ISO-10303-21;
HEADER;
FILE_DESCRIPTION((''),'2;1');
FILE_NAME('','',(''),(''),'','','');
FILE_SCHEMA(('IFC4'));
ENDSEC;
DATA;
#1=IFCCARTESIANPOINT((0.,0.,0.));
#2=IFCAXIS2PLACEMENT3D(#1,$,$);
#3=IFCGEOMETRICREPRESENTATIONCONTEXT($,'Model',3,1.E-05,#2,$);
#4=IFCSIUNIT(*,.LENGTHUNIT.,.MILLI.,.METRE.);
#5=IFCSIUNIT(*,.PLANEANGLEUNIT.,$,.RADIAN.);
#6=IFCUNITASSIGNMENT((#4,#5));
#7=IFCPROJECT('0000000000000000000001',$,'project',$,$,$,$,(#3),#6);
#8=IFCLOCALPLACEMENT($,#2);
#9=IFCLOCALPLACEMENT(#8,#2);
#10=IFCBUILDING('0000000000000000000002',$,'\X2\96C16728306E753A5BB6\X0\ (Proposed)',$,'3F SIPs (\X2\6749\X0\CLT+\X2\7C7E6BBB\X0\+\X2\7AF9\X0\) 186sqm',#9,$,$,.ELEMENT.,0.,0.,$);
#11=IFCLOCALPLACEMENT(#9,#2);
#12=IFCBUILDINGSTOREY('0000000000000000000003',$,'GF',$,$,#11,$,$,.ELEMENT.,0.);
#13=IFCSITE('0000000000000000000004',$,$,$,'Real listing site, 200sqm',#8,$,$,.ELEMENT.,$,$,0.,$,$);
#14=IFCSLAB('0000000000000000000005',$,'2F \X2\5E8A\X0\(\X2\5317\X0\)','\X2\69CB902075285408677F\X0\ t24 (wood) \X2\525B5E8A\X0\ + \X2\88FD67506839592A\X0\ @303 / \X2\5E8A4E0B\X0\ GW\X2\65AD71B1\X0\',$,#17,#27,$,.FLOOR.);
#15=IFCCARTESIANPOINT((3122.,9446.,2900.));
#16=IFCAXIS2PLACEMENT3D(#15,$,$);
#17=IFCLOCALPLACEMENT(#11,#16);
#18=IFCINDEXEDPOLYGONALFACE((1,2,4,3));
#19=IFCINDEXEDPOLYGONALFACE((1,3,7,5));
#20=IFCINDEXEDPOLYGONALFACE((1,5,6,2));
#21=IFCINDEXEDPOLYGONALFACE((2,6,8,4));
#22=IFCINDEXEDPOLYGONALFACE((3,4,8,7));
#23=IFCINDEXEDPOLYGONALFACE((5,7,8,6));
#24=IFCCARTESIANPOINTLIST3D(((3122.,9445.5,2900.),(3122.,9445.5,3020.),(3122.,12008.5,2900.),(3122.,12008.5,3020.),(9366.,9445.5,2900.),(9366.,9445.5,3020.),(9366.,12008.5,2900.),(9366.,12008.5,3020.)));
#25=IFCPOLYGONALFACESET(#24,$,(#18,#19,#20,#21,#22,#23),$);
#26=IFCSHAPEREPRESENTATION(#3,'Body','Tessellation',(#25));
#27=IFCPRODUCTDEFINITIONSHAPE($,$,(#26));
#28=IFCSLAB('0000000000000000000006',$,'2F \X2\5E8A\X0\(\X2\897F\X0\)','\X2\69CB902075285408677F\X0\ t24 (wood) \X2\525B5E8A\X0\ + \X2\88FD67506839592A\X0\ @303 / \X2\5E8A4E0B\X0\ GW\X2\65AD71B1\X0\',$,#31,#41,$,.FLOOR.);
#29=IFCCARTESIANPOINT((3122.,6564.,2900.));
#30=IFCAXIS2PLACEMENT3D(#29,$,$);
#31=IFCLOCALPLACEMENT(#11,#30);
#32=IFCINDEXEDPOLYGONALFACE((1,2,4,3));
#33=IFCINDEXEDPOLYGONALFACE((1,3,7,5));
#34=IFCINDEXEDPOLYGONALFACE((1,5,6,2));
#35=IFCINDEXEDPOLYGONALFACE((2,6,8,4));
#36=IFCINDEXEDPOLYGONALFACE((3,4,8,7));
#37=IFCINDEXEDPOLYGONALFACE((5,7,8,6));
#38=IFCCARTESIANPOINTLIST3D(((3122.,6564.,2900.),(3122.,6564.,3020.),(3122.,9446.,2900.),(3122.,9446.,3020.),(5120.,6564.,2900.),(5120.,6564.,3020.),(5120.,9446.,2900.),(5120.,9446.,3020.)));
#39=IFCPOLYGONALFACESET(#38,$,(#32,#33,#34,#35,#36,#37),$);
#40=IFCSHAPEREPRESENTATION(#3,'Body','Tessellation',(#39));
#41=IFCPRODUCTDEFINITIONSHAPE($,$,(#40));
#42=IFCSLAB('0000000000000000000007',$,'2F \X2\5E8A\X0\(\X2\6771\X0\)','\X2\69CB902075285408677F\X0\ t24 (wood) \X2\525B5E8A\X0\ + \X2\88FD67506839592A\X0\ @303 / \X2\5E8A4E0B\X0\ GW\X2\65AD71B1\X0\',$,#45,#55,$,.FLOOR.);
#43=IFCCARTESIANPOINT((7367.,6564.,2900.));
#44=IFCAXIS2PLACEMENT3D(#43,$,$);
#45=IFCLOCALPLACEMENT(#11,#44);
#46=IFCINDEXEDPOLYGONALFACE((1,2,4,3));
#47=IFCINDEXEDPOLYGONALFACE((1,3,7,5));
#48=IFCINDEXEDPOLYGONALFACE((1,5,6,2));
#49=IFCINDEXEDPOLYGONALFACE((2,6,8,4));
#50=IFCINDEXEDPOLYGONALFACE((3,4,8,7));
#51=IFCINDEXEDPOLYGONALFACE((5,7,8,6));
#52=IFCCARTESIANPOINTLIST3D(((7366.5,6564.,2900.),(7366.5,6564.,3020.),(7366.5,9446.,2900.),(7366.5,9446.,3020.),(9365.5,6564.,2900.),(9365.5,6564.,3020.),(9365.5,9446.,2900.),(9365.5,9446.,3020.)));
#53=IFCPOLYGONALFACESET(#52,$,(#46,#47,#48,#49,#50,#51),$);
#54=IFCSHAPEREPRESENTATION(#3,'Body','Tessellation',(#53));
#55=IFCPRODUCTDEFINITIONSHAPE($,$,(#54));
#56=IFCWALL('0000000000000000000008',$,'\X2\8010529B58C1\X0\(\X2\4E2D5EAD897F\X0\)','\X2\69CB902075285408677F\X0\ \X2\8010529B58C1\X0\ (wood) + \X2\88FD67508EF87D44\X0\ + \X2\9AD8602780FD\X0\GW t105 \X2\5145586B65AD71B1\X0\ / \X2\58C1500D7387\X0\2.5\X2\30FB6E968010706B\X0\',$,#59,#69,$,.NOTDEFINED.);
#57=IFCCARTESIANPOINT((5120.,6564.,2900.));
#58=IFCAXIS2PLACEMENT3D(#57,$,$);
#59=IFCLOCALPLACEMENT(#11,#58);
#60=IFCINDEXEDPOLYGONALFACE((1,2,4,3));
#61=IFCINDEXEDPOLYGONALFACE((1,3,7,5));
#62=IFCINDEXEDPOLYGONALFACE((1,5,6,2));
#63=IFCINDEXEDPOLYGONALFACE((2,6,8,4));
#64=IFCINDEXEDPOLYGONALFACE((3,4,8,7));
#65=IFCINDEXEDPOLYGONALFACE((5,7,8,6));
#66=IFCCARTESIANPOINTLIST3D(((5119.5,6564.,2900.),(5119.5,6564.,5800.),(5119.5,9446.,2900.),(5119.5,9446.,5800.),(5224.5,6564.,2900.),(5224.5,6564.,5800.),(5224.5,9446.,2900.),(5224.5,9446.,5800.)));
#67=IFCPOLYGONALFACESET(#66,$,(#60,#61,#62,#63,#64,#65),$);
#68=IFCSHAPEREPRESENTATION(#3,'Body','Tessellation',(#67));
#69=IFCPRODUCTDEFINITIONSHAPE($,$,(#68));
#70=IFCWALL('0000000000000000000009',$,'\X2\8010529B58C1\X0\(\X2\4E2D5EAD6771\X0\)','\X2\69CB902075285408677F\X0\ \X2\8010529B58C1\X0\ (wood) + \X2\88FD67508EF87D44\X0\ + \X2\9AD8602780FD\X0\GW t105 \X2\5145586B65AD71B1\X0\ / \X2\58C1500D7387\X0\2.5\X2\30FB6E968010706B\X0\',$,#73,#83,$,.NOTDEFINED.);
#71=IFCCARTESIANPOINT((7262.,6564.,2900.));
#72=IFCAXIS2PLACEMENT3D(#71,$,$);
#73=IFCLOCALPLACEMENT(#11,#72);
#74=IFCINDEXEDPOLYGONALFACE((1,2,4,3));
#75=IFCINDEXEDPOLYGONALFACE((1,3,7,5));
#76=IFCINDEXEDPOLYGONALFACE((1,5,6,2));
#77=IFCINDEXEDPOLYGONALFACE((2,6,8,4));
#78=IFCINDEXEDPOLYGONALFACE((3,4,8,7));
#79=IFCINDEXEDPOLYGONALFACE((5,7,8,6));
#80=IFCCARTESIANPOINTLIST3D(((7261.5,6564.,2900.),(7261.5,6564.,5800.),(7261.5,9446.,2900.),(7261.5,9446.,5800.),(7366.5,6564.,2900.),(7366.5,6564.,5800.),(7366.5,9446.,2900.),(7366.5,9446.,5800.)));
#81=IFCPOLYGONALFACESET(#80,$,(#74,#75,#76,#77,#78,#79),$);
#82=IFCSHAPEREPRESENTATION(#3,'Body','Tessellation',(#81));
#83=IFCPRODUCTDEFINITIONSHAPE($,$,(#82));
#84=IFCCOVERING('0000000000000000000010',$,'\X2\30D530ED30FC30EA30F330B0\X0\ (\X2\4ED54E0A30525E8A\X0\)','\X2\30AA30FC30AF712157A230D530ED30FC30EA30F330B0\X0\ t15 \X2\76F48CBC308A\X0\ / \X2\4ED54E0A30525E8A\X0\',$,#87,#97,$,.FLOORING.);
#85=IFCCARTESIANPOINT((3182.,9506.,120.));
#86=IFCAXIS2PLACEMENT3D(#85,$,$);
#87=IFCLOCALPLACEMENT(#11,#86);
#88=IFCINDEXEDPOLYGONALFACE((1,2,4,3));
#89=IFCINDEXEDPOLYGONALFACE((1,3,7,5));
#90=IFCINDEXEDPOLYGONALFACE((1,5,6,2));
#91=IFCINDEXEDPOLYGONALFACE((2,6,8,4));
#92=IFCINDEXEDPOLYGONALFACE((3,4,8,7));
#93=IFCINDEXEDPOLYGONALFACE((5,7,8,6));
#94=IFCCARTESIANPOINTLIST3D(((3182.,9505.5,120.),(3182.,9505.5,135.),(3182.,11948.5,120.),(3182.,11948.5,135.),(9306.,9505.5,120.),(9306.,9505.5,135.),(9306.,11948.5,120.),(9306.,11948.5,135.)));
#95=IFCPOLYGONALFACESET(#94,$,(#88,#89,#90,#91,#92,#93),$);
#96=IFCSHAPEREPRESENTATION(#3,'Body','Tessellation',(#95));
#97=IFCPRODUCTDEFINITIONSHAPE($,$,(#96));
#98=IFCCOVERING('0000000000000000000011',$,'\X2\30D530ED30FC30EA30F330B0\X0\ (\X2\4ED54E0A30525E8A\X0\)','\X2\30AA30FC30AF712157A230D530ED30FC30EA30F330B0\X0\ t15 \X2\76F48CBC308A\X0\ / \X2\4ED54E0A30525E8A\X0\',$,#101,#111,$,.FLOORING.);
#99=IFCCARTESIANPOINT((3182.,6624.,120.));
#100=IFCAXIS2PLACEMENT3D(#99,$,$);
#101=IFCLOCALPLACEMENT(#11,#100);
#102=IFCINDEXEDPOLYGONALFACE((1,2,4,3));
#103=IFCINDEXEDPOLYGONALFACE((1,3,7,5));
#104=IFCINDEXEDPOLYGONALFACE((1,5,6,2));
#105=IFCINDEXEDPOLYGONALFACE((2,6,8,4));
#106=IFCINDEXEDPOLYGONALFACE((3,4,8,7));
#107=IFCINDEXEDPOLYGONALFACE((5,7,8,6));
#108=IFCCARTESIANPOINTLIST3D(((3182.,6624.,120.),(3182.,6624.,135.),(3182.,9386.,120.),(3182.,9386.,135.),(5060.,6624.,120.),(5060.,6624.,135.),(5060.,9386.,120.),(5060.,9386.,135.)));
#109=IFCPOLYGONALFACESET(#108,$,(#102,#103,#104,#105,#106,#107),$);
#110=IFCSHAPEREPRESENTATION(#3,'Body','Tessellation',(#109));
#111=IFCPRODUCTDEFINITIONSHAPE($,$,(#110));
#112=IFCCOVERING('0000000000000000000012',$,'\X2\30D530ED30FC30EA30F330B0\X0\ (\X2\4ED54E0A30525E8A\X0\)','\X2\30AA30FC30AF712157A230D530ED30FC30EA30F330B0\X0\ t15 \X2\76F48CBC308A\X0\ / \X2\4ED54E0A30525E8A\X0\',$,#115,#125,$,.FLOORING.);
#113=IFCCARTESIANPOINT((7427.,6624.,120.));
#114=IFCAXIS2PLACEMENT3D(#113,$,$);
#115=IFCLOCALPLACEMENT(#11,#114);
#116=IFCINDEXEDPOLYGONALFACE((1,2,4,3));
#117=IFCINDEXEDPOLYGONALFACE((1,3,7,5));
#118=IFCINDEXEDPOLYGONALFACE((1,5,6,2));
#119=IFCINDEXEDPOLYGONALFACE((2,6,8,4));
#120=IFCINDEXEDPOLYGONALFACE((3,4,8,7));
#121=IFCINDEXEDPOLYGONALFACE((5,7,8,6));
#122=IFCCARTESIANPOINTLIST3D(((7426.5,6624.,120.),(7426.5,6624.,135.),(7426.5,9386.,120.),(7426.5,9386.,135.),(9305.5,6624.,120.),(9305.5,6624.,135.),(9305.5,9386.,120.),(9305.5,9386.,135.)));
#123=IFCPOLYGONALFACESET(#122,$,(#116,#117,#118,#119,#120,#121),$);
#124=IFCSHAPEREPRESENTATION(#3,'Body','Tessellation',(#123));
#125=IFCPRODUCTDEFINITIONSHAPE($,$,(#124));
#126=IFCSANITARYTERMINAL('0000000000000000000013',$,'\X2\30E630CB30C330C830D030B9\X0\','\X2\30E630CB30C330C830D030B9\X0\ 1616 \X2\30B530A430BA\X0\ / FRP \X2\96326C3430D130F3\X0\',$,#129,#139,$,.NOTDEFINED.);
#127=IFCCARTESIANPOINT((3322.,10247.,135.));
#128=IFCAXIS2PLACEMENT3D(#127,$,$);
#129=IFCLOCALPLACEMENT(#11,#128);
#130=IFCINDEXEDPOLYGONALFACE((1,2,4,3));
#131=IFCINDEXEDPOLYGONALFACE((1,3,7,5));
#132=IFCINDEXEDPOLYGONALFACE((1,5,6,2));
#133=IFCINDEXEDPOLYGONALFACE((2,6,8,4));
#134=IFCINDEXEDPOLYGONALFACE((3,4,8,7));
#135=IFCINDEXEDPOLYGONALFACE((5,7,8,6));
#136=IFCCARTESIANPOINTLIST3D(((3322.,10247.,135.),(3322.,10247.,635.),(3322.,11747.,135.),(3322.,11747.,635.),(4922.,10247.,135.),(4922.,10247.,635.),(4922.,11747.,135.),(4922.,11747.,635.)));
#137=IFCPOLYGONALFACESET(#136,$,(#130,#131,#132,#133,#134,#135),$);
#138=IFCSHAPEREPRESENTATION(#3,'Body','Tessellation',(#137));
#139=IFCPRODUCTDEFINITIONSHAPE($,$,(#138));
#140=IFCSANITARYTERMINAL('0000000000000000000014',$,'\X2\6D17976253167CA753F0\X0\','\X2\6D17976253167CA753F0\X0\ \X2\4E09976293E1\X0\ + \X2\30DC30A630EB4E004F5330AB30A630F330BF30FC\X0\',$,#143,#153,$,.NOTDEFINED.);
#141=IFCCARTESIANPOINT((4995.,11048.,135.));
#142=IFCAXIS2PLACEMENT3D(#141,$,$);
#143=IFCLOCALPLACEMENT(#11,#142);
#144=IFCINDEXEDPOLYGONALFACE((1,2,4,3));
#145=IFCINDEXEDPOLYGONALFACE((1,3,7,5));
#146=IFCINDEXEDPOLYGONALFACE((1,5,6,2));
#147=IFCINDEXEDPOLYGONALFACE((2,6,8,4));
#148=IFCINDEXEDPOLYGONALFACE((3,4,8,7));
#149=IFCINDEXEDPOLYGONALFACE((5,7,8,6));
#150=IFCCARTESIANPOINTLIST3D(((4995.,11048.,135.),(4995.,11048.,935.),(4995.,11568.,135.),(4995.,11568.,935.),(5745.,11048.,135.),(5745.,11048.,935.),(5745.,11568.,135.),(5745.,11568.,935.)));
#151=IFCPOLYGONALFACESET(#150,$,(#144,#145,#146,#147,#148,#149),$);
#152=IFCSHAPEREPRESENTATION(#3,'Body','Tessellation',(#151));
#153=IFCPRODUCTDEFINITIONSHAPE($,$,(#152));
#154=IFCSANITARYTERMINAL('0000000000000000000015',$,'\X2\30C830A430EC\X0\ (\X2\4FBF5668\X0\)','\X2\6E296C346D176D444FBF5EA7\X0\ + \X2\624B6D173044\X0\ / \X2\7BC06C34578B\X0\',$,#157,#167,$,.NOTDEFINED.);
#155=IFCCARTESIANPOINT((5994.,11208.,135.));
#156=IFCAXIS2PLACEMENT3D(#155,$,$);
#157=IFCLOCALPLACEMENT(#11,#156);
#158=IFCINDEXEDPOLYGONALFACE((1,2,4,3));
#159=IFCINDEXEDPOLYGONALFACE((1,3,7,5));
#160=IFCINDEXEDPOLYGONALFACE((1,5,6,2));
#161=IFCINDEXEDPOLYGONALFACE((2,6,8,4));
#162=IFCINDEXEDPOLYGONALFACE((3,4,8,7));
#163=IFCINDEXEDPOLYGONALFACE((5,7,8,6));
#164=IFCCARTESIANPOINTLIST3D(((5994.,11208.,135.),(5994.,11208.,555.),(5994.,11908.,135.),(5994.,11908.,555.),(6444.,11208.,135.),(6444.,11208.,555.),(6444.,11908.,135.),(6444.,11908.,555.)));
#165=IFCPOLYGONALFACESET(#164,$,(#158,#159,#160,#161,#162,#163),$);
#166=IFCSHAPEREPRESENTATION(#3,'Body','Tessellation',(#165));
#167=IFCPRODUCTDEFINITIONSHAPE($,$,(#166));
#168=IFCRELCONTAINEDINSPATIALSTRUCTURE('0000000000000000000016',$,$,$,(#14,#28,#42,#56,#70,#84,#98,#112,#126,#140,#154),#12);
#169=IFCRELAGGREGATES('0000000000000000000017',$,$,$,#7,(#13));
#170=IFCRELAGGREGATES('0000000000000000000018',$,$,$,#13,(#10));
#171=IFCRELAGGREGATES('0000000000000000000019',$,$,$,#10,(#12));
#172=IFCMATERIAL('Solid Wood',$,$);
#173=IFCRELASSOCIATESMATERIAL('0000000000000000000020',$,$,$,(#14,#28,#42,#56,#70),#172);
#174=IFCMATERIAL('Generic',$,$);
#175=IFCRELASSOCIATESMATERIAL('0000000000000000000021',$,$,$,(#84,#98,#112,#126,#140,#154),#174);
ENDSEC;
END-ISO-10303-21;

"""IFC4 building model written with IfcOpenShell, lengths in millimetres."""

from ifc_helpers import new_model, si_unit, frame, frame_2d, origin, place, context, project, spatial, rectangle, extrude, material, element, save


model = new_model("IFC4")

# Units and contexts
model_context = context("Model", 3, precision=1e-05, world=origin())
ifc_project = project(units=[si_unit("LENGTHUNIT", "METRE", prefix="MILLI"), si_unit("PLANEANGLEUNIT", "RADIAN")], contexts=[model_context])

# Site, building, storey
site_placement = place(None, origin())
site = spatial("IfcSite", under=ifc_project, at=site_placement, ObjectType="Real listing site, 200sqm", CompositionType="ELEMENT", RefElevation=0.0)
building_placement = place(site_placement, origin())
building = spatial("IfcBuilding", under=site, at=building_placement, Name="雁木の町家 (Proposed)", ObjectType="3F SIPs (杉CLT+籾殻+竹) 186sqm", CompositionType="ELEMENT", ElevationOfRefHeight=0.0, ElevationOfTerrain=0.0)
storey_placement = place(building_placement, origin())
storey = spatial("IfcBuildingStorey", under=building, at=storey_placement, Name="GF", CompositionType="ELEMENT", Elevation=0.0)

# Slabs
ifc_material_1 = material(Name="Solid Wood")
slab_1_placement = place(storey_placement, frame((3122.0, 9446.0, 2900.0)))
element("IfcSlab", 1, at=slab_1_placement, inside=storey, material=ifc_material_1, Name="2F 床(北)", Description="構造用合板 t24 (wood) 剛床 + 製材根太 @303 / 床下 GW断熱", PredefinedType="FLOOR", context=model_context, shape_type="SweptSolid", body=[
    extrude(rectangle(XDim=6244.0, YDim=2563.0, at=frame_2d((3122.0, 1281.0))), frame((3122.0, 9446.0, 2900.0)), (0.0, 0.0, 1.0), 120.0),
])
slab_2_placement = place(storey_placement, frame((3122.0, 6564.0, 2900.0)))
element("IfcSlab", 2, at=slab_2_placement, inside=storey, material=ifc_material_1, Name="2F 床(西)", Description="構造用合板 t24 (wood) 剛床 + 製材根太 @303 / 床下 GW断熱", PredefinedType="FLOOR", context=model_context, shape_type="SweptSolid", body=[
    extrude(rectangle(XDim=1998.0, YDim=2882.0, at=frame_2d((999.0, 1441.0))), frame((3122.0, 6564.0, 2900.0)), (0.0, 0.0, 1.0), 120.0),
])
slab_3_placement = place(storey_placement, frame((7367.0, 6564.0, 2900.0)))
element("IfcSlab", 3, at=slab_3_placement, inside=storey, material=ifc_material_1, Name="2F 床(東)", Description="構造用合板 t24 (wood) 剛床 + 製材根太 @303 / 床下 GW断熱", PredefinedType="FLOOR", context=model_context, shape_type="SweptSolid", body=[
    extrude(rectangle(XDim=1999.0, YDim=2882.0, at=frame_2d((999.0, 1441.0))), frame((7367.0, 6564.0, 2900.0)), (0.0, 0.0, 1.0), 120.0),
])

# Walls
wall_1_placement = place(storey_placement, frame((5120.0, 6564.0, 2900.0)))
element("IfcWall", 4, at=wall_1_placement, inside=storey, material=ifc_material_1, Name="耐力壁(中庭西)", Description="構造用合板 耐力壁 (wood) + 製材軸組 + 高性能GW t105 充填断熱 / 壁倍率2.5・準耐火", PredefinedType="NOTDEFINED", context=model_context, shape_type="SweptSolid", body=[
    extrude(rectangle(XDim=105.0, YDim=2882.0, at=frame_2d((52.0, 1441.0))), frame((5120.0, 6564.0, 2900.0)), (0.0, 0.0, 1.0), 2900.0),
])
wall_2_placement = place(storey_placement, frame((7262.0, 6564.0, 2900.0)))
element("IfcWall", 5, at=wall_2_placement, inside=storey, material=ifc_material_1, Name="耐力壁(中庭東)", Description="構造用合板 耐力壁 (wood) + 製材軸組 + 高性能GW t105 充填断熱 / 壁倍率2.5・準耐火", PredefinedType="NOTDEFINED", context=model_context, shape_type="SweptSolid", body=[
    extrude(rectangle(XDim=105.0, YDim=2882.0, at=frame_2d((52.0, 1441.0))), frame((7262.0, 6564.0, 2900.0)), (0.0, 0.0, 1.0), 2900.0),
])

# Coverings
ifc_material_2 = material(Name="Generic")
covering_1_placement = place(storey_placement, frame((3182.0, 9506.0, 120.0)))
element("IfcCovering", 6, at=covering_1_placement, inside=storey, material=ifc_material_2, Name="フローリング (仕上げ床)", Description="オーク無垢フローリング t15 直貼り / 仕上げ床", PredefinedType="FLOORING", context=model_context, shape_type="SweptSolid", body=[
    extrude(rectangle(XDim=6124.0, YDim=2443.0, at=frame_2d((3062.0, 1221.0))), frame((3182.0, 9506.0, 120.0)), (0.0, 0.0, 1.0), 15.0),
])
covering_2_placement = place(storey_placement, frame((3182.0, 6624.0, 120.0)))
element("IfcCovering", 7, at=covering_2_placement, inside=storey, material=ifc_material_2, Name="フローリング (仕上げ床)", Description="オーク無垢フローリング t15 直貼り / 仕上げ床", PredefinedType="FLOORING", context=model_context, shape_type="SweptSolid", body=[
    extrude(rectangle(XDim=1878.0, YDim=2762.0, at=frame_2d((939.0, 1381.0))), frame((3182.0, 6624.0, 120.0)), (0.0, 0.0, 1.0), 15.0),
])
covering_3_placement = place(storey_placement, frame((7427.0, 6624.0, 120.0)))
element("IfcCovering", 8, at=covering_3_placement, inside=storey, material=ifc_material_2, Name="フローリング (仕上げ床)", Description="オーク無垢フローリング t15 直貼り / 仕上げ床", PredefinedType="FLOORING", context=model_context, shape_type="SweptSolid", body=[
    extrude(rectangle(XDim=1879.0, YDim=2762.0, at=frame_2d((939.0, 1381.0))), frame((7427.0, 6624.0, 120.0)), (0.0, 0.0, 1.0), 15.0),
])

# Sanitary terminals
sanitary_terminal_1_placement = place(storey_placement, frame((3322.0, 10247.0, 135.0)))
element("IfcSanitaryTerminal", 9, at=sanitary_terminal_1_placement, inside=storey, material=ifc_material_2, Name="ユニットバス", Description="ユニットバス 1616 サイズ / FRP 防水パン", PredefinedType="NOTDEFINED", context=model_context, shape_type="SweptSolid", body=[
    extrude(rectangle(XDim=1600.0, YDim=1500.0, at=frame_2d((800.0, 750.0))), frame((3322.0, 10247.0, 135.0)), (0.0, 0.0, 1.0), 500.0),
])
sanitary_terminal_2_placement = place(storey_placement, frame((4995.0, 11048.0, 135.0)))
element("IfcSanitaryTerminal", 10, at=sanitary_terminal_2_placement, inside=storey, material=ifc_material_2, Name="洗面化粧台", Description="洗面化粧台 三面鏡 + ボウル一体カウンター", PredefinedType="NOTDEFINED", context=model_context, shape_type="SweptSolid", body=[
    extrude(rectangle(XDim=750.0, YDim=520.0, at=frame_2d((375.0, 260.0))), frame((4995.0, 11048.0, 135.0)), (0.0, 0.0, 1.0), 800.0),
])
sanitary_terminal_3_placement = place(storey_placement, frame((5994.0, 11208.0, 135.0)))
element("IfcSanitaryTerminal", 11, at=sanitary_terminal_3_placement, inside=storey, material=ifc_material_2, Name="トイレ (便器)", Description="温水洗浄便座 + 手洗い / 節水型", PredefinedType="NOTDEFINED", context=model_context, shape_type="SweptSolid", body=[
    extrude(rectangle(XDim=450.0, YDim=700.0, at=frame_2d((225.0, 350.0))), frame((5994.0, 11208.0, 135.0)), (0.0, 0.0, 1.0), 420.0),
])

save(model, "model.ifc")
